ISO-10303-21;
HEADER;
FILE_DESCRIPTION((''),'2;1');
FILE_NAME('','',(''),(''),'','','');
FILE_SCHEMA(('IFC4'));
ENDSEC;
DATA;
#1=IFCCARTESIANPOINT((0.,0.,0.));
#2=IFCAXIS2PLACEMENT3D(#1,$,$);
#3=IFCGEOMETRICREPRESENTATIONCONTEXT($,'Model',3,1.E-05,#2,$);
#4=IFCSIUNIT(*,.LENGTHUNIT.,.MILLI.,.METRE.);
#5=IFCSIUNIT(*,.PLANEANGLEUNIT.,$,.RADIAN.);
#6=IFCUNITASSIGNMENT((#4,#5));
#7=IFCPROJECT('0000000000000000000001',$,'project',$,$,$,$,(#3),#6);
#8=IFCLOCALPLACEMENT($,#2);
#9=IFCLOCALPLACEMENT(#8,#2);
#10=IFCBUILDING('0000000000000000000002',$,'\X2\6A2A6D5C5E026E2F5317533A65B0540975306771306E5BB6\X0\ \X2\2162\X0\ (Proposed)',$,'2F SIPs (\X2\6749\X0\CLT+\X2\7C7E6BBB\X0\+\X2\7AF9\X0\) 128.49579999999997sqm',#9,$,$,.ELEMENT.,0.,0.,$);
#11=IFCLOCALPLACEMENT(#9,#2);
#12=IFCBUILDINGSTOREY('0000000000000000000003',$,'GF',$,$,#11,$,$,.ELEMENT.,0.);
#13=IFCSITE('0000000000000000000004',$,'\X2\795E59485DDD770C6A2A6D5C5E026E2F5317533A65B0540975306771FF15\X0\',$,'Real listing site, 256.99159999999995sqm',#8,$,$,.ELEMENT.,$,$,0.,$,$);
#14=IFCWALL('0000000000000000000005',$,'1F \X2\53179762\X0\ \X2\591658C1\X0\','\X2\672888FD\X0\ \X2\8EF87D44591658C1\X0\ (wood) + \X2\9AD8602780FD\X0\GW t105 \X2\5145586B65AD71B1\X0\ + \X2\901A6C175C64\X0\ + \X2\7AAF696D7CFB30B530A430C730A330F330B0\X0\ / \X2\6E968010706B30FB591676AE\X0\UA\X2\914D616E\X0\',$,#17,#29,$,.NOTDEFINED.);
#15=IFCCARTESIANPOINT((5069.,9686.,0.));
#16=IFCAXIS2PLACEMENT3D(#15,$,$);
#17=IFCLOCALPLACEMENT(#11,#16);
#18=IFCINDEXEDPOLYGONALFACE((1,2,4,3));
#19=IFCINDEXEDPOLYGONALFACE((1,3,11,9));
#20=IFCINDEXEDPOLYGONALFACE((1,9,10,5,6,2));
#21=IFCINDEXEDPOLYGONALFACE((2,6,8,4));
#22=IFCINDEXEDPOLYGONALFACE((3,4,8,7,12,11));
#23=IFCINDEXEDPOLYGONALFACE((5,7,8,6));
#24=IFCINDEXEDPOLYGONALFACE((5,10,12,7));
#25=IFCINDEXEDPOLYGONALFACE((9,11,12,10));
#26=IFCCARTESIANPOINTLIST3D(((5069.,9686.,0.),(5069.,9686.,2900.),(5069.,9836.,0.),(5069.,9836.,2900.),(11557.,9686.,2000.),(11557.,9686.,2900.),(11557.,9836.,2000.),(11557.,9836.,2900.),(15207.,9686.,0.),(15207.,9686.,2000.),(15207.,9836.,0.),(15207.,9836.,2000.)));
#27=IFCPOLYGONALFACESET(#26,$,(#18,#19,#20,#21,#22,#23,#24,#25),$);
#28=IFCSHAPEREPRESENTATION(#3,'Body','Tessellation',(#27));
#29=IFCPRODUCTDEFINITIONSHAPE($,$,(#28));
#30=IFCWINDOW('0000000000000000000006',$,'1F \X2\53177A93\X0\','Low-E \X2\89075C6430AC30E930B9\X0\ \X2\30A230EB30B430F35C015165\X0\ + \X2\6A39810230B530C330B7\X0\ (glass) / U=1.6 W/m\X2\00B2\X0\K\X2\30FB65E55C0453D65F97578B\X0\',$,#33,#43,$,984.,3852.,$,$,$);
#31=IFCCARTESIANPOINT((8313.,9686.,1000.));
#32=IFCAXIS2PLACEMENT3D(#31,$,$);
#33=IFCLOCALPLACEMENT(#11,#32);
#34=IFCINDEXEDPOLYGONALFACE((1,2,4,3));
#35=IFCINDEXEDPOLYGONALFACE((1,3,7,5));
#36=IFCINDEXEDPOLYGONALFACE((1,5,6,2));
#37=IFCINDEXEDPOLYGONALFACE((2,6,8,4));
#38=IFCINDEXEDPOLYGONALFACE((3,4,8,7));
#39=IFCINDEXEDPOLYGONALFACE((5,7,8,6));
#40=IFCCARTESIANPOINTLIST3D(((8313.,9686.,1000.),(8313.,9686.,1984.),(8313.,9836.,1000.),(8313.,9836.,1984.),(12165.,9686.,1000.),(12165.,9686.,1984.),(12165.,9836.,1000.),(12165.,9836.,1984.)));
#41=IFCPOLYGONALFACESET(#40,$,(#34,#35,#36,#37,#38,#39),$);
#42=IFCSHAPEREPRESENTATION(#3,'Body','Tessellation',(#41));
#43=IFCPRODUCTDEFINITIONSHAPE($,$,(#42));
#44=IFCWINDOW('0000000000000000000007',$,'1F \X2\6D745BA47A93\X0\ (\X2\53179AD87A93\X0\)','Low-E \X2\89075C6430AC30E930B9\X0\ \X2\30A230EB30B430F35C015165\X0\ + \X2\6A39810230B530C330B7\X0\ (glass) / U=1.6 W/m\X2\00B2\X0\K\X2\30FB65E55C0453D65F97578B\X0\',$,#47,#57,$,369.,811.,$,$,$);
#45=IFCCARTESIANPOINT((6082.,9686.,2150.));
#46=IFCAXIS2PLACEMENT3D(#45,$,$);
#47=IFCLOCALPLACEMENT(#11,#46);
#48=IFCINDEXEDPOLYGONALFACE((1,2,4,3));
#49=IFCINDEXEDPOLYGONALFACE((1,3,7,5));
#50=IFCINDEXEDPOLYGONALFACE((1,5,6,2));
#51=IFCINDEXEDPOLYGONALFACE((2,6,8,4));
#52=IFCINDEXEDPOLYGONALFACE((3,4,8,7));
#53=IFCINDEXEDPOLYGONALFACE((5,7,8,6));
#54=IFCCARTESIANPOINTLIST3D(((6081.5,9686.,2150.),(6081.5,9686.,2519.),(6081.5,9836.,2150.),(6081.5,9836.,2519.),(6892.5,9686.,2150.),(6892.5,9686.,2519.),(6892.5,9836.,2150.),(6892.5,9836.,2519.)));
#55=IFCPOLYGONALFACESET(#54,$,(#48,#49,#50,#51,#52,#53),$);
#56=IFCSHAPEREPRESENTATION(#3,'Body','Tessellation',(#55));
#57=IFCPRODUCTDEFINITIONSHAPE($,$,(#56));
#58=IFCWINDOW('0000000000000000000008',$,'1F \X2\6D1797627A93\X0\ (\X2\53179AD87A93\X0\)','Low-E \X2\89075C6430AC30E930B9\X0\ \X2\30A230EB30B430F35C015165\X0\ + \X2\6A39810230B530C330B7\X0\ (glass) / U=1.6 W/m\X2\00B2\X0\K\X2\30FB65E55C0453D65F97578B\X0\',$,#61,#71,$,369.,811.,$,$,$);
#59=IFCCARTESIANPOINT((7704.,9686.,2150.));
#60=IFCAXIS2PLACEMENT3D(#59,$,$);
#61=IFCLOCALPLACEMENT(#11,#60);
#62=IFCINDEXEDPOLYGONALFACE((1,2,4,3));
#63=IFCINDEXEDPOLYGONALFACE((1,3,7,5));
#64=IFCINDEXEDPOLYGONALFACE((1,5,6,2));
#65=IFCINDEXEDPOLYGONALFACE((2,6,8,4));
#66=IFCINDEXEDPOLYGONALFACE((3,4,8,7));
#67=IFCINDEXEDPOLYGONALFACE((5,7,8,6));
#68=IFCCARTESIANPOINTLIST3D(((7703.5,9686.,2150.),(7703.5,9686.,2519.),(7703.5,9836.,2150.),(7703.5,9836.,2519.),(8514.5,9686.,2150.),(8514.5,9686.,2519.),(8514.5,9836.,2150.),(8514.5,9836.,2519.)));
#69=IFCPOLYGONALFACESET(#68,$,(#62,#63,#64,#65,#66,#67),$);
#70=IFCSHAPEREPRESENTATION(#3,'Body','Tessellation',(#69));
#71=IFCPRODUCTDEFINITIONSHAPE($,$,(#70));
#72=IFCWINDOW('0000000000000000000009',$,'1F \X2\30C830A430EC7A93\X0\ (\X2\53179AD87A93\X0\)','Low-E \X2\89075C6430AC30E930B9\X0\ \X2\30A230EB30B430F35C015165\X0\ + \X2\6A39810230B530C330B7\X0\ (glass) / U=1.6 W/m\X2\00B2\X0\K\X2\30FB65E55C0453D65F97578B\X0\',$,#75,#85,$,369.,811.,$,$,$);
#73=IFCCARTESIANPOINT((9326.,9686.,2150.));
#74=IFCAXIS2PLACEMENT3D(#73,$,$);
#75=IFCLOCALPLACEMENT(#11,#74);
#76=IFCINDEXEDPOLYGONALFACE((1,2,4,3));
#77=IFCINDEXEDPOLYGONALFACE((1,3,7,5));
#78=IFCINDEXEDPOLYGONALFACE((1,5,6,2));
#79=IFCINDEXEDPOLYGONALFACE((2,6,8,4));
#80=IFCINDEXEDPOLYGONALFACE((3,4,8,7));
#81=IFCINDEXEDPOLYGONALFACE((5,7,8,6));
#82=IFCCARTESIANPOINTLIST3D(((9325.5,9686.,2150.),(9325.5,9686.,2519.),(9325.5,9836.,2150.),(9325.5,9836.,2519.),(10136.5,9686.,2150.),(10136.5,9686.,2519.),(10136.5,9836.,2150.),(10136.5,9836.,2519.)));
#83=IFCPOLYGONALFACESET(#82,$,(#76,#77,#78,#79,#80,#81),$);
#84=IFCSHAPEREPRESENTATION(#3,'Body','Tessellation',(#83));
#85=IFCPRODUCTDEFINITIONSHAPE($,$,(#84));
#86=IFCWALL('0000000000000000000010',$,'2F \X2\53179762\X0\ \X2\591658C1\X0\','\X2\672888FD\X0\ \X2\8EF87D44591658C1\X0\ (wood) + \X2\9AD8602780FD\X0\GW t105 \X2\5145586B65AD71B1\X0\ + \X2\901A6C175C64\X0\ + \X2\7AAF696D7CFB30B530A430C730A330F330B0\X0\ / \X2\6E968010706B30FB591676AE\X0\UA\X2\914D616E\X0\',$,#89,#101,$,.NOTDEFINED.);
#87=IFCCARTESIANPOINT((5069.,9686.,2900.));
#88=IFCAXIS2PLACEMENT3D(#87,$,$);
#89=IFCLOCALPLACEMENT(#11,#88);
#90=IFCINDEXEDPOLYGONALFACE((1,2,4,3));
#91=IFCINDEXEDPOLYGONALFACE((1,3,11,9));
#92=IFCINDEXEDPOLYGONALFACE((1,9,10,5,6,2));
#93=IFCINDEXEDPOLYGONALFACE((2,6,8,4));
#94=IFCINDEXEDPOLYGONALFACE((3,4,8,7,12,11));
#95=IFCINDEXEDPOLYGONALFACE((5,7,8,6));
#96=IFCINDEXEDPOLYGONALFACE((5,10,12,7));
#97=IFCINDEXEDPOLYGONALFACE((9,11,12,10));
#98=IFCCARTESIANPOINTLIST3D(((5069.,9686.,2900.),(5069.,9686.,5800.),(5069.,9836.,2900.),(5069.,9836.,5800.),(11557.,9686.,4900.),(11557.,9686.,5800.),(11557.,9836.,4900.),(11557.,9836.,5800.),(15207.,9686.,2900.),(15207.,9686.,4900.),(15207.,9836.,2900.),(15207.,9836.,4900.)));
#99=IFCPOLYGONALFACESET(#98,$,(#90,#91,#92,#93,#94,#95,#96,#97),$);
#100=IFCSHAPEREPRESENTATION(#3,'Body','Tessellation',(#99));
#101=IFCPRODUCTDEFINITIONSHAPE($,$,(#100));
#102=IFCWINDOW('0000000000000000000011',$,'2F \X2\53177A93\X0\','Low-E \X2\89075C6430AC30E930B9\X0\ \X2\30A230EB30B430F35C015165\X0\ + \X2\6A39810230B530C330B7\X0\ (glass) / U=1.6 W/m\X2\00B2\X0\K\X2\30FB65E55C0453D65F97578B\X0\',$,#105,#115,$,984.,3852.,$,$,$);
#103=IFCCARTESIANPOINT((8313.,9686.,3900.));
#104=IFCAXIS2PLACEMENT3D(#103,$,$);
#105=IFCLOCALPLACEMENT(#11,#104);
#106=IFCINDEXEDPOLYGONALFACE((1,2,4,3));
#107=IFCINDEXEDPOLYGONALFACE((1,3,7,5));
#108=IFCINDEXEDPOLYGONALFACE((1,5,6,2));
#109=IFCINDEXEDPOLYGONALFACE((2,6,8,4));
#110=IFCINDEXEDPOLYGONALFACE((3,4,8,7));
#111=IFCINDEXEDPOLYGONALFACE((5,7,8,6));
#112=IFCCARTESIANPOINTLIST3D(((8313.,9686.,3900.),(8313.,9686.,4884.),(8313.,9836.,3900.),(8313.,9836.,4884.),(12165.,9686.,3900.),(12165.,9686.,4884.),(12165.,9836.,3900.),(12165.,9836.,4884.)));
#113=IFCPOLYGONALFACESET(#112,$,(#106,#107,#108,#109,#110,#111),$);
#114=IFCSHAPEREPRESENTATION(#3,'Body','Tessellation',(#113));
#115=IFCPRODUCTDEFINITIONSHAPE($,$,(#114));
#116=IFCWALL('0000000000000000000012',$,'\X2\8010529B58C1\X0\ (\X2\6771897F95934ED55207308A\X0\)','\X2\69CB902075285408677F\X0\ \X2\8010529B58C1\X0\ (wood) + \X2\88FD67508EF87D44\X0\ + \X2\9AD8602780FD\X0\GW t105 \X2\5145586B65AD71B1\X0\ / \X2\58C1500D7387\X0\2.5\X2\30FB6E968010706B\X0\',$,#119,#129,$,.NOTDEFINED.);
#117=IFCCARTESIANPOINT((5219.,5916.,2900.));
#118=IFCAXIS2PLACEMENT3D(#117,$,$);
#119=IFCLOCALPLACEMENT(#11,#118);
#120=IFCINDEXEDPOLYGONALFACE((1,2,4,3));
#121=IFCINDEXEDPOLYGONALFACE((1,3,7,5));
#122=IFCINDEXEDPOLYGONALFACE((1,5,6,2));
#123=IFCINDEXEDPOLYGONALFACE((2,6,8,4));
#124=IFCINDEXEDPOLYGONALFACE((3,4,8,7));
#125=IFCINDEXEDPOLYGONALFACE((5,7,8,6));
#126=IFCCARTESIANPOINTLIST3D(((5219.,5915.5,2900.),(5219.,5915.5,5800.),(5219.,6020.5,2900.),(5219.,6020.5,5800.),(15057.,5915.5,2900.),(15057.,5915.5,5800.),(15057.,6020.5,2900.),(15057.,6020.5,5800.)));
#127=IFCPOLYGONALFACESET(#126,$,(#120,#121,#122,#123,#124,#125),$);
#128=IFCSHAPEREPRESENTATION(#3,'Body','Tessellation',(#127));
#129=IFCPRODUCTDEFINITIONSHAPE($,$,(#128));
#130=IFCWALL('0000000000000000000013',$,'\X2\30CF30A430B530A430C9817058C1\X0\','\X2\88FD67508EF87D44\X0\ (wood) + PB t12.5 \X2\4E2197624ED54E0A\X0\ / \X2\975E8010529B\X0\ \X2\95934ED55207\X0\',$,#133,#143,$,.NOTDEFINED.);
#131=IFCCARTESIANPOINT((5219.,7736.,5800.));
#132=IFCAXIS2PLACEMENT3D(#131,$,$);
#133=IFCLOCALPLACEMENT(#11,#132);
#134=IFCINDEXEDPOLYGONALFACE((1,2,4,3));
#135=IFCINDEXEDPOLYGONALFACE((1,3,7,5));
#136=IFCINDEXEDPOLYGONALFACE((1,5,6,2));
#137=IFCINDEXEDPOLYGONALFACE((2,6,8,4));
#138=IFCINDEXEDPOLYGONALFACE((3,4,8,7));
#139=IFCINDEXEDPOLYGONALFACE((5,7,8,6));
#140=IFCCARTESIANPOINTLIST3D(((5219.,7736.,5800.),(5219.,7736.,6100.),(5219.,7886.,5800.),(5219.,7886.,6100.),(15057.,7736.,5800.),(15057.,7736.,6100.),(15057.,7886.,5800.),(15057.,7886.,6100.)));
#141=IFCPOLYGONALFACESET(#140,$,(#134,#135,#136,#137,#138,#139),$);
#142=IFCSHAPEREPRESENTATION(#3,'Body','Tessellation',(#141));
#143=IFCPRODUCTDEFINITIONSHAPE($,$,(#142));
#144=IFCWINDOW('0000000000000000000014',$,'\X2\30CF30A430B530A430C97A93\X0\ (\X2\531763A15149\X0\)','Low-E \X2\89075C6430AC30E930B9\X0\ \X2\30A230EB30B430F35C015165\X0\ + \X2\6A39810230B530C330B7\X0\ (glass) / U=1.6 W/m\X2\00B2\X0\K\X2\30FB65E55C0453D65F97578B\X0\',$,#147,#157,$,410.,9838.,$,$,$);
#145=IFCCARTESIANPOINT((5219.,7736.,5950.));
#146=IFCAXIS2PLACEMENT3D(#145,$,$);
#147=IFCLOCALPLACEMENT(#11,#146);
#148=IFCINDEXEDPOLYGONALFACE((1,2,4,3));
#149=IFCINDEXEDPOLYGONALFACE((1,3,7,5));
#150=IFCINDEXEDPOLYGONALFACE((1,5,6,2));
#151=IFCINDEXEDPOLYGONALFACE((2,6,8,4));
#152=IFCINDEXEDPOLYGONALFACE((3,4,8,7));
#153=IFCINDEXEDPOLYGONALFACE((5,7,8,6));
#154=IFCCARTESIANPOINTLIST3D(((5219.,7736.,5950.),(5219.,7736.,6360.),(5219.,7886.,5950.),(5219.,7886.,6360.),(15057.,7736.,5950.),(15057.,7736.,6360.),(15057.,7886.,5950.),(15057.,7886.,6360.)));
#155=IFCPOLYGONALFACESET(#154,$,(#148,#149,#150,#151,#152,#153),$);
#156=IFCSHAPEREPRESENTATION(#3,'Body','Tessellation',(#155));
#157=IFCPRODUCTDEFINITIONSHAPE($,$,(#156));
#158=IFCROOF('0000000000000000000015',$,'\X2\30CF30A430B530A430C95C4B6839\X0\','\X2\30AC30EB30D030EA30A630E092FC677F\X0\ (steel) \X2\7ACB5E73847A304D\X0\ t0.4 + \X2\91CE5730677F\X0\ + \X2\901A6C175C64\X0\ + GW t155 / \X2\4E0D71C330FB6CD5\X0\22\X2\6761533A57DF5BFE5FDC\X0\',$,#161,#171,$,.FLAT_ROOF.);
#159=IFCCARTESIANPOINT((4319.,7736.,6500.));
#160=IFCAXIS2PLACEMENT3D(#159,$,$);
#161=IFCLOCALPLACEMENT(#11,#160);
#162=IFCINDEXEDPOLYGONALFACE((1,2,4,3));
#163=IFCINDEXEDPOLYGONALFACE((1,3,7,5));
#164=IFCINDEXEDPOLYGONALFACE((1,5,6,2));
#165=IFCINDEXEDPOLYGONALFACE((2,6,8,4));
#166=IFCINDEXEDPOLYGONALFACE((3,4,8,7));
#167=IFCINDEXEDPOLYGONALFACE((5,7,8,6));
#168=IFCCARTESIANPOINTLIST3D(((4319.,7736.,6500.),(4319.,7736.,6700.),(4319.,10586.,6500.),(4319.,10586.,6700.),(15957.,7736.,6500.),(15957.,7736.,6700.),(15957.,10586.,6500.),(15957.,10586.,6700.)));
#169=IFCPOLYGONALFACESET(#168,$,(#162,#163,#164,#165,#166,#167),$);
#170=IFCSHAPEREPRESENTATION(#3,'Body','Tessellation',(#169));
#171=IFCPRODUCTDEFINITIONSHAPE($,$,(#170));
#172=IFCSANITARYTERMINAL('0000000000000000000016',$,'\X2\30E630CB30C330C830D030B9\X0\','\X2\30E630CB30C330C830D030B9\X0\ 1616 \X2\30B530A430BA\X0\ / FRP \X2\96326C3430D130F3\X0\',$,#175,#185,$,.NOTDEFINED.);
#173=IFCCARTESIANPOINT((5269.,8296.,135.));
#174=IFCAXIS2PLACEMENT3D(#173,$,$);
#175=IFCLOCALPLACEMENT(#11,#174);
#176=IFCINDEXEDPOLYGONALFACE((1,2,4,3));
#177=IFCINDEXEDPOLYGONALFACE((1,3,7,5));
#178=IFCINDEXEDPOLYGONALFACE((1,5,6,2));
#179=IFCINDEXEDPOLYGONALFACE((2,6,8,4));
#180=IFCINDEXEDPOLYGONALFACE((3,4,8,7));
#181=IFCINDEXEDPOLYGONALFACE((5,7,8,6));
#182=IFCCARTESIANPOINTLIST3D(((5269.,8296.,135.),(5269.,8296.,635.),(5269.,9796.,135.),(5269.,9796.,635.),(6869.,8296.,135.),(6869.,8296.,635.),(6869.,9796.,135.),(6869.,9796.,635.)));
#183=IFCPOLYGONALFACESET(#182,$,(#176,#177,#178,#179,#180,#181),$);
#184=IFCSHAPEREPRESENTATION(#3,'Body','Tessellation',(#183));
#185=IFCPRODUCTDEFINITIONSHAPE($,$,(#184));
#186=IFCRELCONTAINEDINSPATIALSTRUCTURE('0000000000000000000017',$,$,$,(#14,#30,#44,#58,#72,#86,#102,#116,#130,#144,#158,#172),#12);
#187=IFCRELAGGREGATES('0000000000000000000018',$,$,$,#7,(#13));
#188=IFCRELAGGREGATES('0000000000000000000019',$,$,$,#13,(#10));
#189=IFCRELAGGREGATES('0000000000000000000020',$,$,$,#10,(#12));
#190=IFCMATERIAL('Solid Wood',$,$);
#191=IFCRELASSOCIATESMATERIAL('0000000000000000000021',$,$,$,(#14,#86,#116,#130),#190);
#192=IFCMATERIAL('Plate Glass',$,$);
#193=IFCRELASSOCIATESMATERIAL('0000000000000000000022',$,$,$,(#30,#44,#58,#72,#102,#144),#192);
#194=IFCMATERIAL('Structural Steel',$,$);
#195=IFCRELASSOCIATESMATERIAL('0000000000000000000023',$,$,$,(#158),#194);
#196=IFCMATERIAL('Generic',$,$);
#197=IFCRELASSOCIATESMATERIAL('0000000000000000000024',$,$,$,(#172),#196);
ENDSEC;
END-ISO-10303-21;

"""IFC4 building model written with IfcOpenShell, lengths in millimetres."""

from ifc_helpers import new_model, si_unit, frame, frame_2d, origin, place, context, project, spatial, rectangle, extrude, material, element, fill, save


model = new_model("IFC4")

# Units and contexts
model_context = context("Model", 3, precision=1e-05, world=origin())
ifc_project = project(units=[si_unit("LENGTHUNIT", "METRE", prefix="MILLI"), si_unit("PLANEANGLEUNIT", "RADIAN")], contexts=[model_context])

# Site, building, storey
site_placement = place(None, origin())
site = spatial("IfcSite", under=ifc_project, at=site_placement, Name="神奈川県横浜市港北区新吉田東５", ObjectType="Real listing site, 256.99159999999995sqm", CompositionType="ELEMENT", RefElevation=0.0)
building_placement = place(site_placement, origin())
building = spatial("IfcBuilding", under=site, at=building_placement, Name="横浜市港北区新吉田東の家 Ⅲ (Proposed)", ObjectType="2F SIPs (杉CLT+籾殻+竹) 128.49579999999997sqm", CompositionType="ELEMENT", ElevationOfRefHeight=0.0, ElevationOfTerrain=0.0)
storey_placement = place(building_placement, origin())
storey = spatial("IfcBuildingStorey", under=building, at=storey_placement, Name="GF", CompositionType="ELEMENT", Elevation=0.0)

# Wall, openings, windows
ifc_material_1 = material(Name="Solid Wood")
wall_1_placement = place(storey_placement, frame((5069.0, 9686.0, 0.0)))
wall_1 = element("IfcWall", 1, at=wall_1_placement, inside=storey, material=ifc_material_1, Name="1F 北面 外壁", Description="木製 軸組外壁 (wood) + 高性能GW t105 充填断熱 + 通気層 + 窯業系サイディング / 準耐火・外皮UA配慮", PredefinedType="NOTDEFINED", context=model_context, shape_type="SweptSolid", body=[
    extrude(rectangle(XDim=10138.0, YDim=150.0, at=frame_2d((5069.0, 75.0))), frame((5069.0, 9686.0, 0.0)), (0.0, 0.0, 1.0), 2900.0),
])
opening_1_placement = place(storey_placement, frame((8313.0, 9686.0, 1000.0)))
opening_1 = element("IfcOpeningElement", 2, at=opening_1_placement, cuts=wall_1, PredefinedType="NOTDEFINED", context=model_context, shape_type="SweptSolid", body=[
    extrude(rectangle(XDim=3852.0, YDim=150.0, at=frame_2d((1926.0, 75.0))), frame((8313.0, 9686.0, 1000.0)), (0.0, 0.0, 1.0), 984.0),
])
opening_2_placement = place(storey_placement, frame((6082.0, 9686.0, 2150.0)))
opening_2 = element("IfcOpeningElement", 3, at=opening_2_placement, cuts=wall_1, PredefinedType="NOTDEFINED", context=model_context, shape_type="SweptSolid", body=[
    extrude(rectangle(XDim=811.0, YDim=150.0, at=frame_2d((405.0, 75.0))), frame((6082.0, 9686.0, 2150.0)), (0.0, 0.0, 1.0), 369.0),
])
opening_3_placement = place(storey_placement, frame((7704.0, 9686.0, 2150.0)))
opening_3 = element("IfcOpeningElement", 4, at=opening_3_placement, cuts=wall_1, PredefinedType="NOTDEFINED", context=model_context, shape_type="SweptSolid", body=[
    extrude(rectangle(XDim=811.0, YDim=150.0, at=frame_2d((405.0, 75.0))), frame((7704.0, 9686.0, 2150.0)), (0.0, 0.0, 1.0), 369.0),
])
opening_4_placement = place(storey_placement, frame((9326.0, 9686.0, 2150.0)))
opening_4 = element("IfcOpeningElement", 5, at=opening_4_placement, cuts=wall_1, PredefinedType="NOTDEFINED", context=model_context, shape_type="SweptSolid", body=[
    extrude(rectangle(XDim=811.0, YDim=150.0, at=frame_2d((405.0, 75.0))), frame((9326.0, 9686.0, 2150.0)), (0.0, 0.0, 1.0), 369.0),
])
ifc_material_2 = material(Name="Plate Glass")
window_1_placement = place(storey_placement, frame((8313.0, 9686.0, 1000.0)))
window_1 = element("IfcWindow", 6, at=window_1_placement, inside=storey, material=ifc_material_2, Name="1F 北窓", Description="Low-E 複層ガラス アルゴン封入 + 樹脂サッシ (glass) / U=1.6 W/m²K・日射取得型", OverallHeight=984.0, OverallWidth=3852.0, context=model_context, shape_type="SweptSolid", body=[
    extrude(rectangle(XDim=3852.0, YDim=150.0, at=frame_2d((1926.0, 75.0))), frame((8313.0, 9686.0, 1000.0)), (0.0, 0.0, 1.0), 984.0),
])
fill(opening_1, window_1)
window_2_placement = place(storey_placement, frame((6082.0, 9686.0, 2150.0)))
window_2 = element("IfcWindow", 7, at=window_2_placement, inside=storey, material=ifc_material_2, Name="1F 浴室窓 (北高窓)", Description="Low-E 複層ガラス アルゴン封入 + 樹脂サッシ (glass) / U=1.6 W/m²K・日射取得型", OverallHeight=369.0, OverallWidth=811.0, context=model_context, shape_type="SweptSolid", body=[
    extrude(rectangle(XDim=811.0, YDim=150.0, at=frame_2d((405.0, 75.0))), frame((6082.0, 9686.0, 2150.0)), (0.0, 0.0, 1.0), 369.0),
])
fill(opening_2, window_2)
window_3_placement = place(storey_placement, frame((7704.0, 9686.0, 2150.0)))
window_3 = element("IfcWindow", 8, at=window_3_placement, inside=storey, material=ifc_material_2, Name="1F 洗面窓 (北高窓)", Description="Low-E 複層ガラス アルゴン封入 + 樹脂サッシ (glass) / U=1.6 W/m²K・日射取得型", OverallHeight=369.0, OverallWidth=811.0, context=model_context, shape_type="SweptSolid", body=[
    extrude(rectangle(XDim=811.0, YDim=150.0, at=frame_2d((405.0, 75.0))), frame((7704.0, 9686.0, 2150.0)), (0.0, 0.0, 1.0), 369.0),
])
fill(opening_3, window_3)
window_4_placement = place(storey_placement, frame((9326.0, 9686.0, 2150.0)))
window_4 = element("IfcWindow", 9, at=window_4_placement, inside=storey, material=ifc_material_2, Name="1F トイレ窓 (北高窓)", Description="Low-E 複層ガラス アルゴン封入 + 樹脂サッシ (glass) / U=1.6 W/m²K・日射取得型", OverallHeight=369.0, OverallWidth=811.0, context=model_context, shape_type="SweptSolid", body=[
    extrude(rectangle(XDim=811.0, YDim=150.0, at=frame_2d((405.0, 75.0))), frame((9326.0, 9686.0, 2150.0)), (0.0, 0.0, 1.0), 369.0),
])
fill(opening_4, window_4)

# Wall, opening, window
wall_2_placement = place(storey_placement, frame((5069.0, 9686.0, 2900.0)))
wall_2 = element("IfcWall", 10, at=wall_2_placement, inside=storey, material=ifc_material_1, Name="2F 北面 外壁", Description="木製 軸組外壁 (wood) + 高性能GW t105 充填断熱 + 通気層 + 窯業系サイディング / 準耐火・外皮UA配慮", PredefinedType="NOTDEFINED", context=model_context, shape_type="SweptSolid", body=[
    extrude(rectangle(XDim=10138.0, YDim=150.0, at=frame_2d((5069.0, 75.0))), frame((5069.0, 9686.0, 2900.0)), (0.0, 0.0, 1.0), 2900.0),
])
opening_5_placement = place(storey_placement, frame((8313.0, 9686.0, 3900.0)))
opening_5 = element("IfcOpeningElement", 11, at=opening_5_placement, cuts=wall_2, PredefinedType="NOTDEFINED", context=model_context, shape_type="SweptSolid", body=[
    extrude(rectangle(XDim=3852.0, YDim=150.0, at=frame_2d((1926.0, 75.0))), frame((8313.0, 9686.0, 3900.0)), (0.0, 0.0, 1.0), 984.0),
])
window_5_placement = place(storey_placement, frame((8313.0, 9686.0, 3900.0)))
window_5 = element("IfcWindow", 12, at=window_5_placement, inside=storey, material=ifc_material_2, Name="2F 北窓", Description="Low-E 複層ガラス アルゴン封入 + 樹脂サッシ (glass) / U=1.6 W/m²K・日射取得型", OverallHeight=984.0, OverallWidth=3852.0, context=model_context, shape_type="SweptSolid", body=[
    extrude(rectangle(XDim=3852.0, YDim=150.0, at=frame_2d((1926.0, 75.0))), frame((8313.0, 9686.0, 3900.0)), (0.0, 0.0, 1.0), 984.0),
])
fill(opening_5, window_5)

# Wall
wall_3_placement = place(storey_placement, frame((5219.0, 5916.0, 2900.0)))
element("IfcWall", 13, at=wall_3_placement, inside=storey, material=ifc_material_1, Name="耐力壁 (東西間仕切り)", Description="構造用合板 耐力壁 (wood) + 製材軸組 + 高性能GW t105 充填断熱 / 壁倍率2.5・準耐火", PredefinedType="NOTDEFINED", context=model_context, shape_type="SweptSolid", body=[
    extrude(rectangle(XDim=9838.0, YDim=105.0, at=frame_2d((4919.0, 52.0))), frame((5219.0, 5916.0, 2900.0)), (0.0, 0.0, 1.0), 2900.0),
])

# Wall, opening, window
wall_4_placement = place(storey_placement, frame((5219.0, 7736.0, 5800.0)))
wall_4 = element("IfcWall", 14, at=wall_4_placement, inside=storey, material=ifc_material_1, Name="ハイサイド腰壁", Description="製材軸組 (wood) + PB t12.5 両面仕上 / 非耐力 間仕切", PredefinedType="NOTDEFINED", context=model_context, shape_type="SweptSolid", body=[
    extrude(rectangle(XDim=9838.0, YDim=150.0, at=frame_2d((4919.0, 75.0))), frame((5219.0, 7736.0, 5800.0)), (0.0, 0.0, 1.0), 700.0),
])
opening_6_placement = place(storey_placement, frame((5219.0, 7736.0, 5950.0)))
opening_6 = element("IfcOpeningElement", 15, at=opening_6_placement, cuts=wall_4, PredefinedType="NOTDEFINED", context=model_context, shape_type="SweptSolid", body=[
    extrude(rectangle(XDim=9838.0, YDim=150.0, at=frame_2d((4919.0, 75.0))), frame((5219.0, 7736.0, 5950.0)), (0.0, 0.0, 1.0), 410.0),
])
window_6_placement = place(storey_placement, frame((5219.0, 7736.0, 5950.0)))
window_6 = element("IfcWindow", 16, at=window_6_placement, inside=storey, material=ifc_material_2, Name="ハイサイド窓 (北採光)", Description="Low-E 複層ガラス アルゴン封入 + 樹脂サッシ (glass) / U=1.6 W/m²K・日射取得型", OverallHeight=410.0, OverallWidth=9838.0, context=model_context, shape_type="SweptSolid", body=[
    extrude(rectangle(XDim=9838.0, YDim=150.0, at=frame_2d((4919.0, 75.0))), frame((5219.0, 7736.0, 5950.0)), (0.0, 0.0, 1.0), 410.0),
])
fill(opening_6, window_6)

# Roof
ifc_material_3 = material(Name="Structural Steel")
roof_placement = place(storey_placement, frame((4319.0, 7736.0, 6500.0)))
element("IfcRoof", 17, at=roof_placement, inside=storey, material=ifc_material_3, Name="ハイサイド屋根", Description="ガルバリウム鋼板 (steel) 立平葺き t0.4 + 野地板 + 通気層 + GW t155 / 不燃・法22条区域対応", PredefinedType="FLAT_ROOF", context=model_context, shape_type="SweptSolid", body=[
    extrude(rectangle(XDim=11638.0, YDim=2850.0, at=frame_2d((5819.0, 1425.0))), frame((4319.0, 7736.0, 6500.0)), (0.0, 0.0, 1.0), 200.0),
])

# Sanitary terminal
ifc_material_4 = material(Name="Generic")
sanitary_terminal_placement = place(storey_placement, frame((5269.0, 8296.0, 135.0)))
element("IfcSanitaryTerminal", 18, at=sanitary_terminal_placement, inside=storey, material=ifc_material_4, Name="ユニットバス", Description="ユニットバス 1616 サイズ / FRP 防水パン", PredefinedType="NOTDEFINED", context=model_context, shape_type="SweptSolid", body=[
    extrude(rectangle(XDim=1600.0, YDim=1500.0, at=frame_2d((800.0, 750.0))), frame((5269.0, 8296.0, 135.0)), (0.0, 0.0, 1.0), 500.0),
])

save(model, "model.ifc")
